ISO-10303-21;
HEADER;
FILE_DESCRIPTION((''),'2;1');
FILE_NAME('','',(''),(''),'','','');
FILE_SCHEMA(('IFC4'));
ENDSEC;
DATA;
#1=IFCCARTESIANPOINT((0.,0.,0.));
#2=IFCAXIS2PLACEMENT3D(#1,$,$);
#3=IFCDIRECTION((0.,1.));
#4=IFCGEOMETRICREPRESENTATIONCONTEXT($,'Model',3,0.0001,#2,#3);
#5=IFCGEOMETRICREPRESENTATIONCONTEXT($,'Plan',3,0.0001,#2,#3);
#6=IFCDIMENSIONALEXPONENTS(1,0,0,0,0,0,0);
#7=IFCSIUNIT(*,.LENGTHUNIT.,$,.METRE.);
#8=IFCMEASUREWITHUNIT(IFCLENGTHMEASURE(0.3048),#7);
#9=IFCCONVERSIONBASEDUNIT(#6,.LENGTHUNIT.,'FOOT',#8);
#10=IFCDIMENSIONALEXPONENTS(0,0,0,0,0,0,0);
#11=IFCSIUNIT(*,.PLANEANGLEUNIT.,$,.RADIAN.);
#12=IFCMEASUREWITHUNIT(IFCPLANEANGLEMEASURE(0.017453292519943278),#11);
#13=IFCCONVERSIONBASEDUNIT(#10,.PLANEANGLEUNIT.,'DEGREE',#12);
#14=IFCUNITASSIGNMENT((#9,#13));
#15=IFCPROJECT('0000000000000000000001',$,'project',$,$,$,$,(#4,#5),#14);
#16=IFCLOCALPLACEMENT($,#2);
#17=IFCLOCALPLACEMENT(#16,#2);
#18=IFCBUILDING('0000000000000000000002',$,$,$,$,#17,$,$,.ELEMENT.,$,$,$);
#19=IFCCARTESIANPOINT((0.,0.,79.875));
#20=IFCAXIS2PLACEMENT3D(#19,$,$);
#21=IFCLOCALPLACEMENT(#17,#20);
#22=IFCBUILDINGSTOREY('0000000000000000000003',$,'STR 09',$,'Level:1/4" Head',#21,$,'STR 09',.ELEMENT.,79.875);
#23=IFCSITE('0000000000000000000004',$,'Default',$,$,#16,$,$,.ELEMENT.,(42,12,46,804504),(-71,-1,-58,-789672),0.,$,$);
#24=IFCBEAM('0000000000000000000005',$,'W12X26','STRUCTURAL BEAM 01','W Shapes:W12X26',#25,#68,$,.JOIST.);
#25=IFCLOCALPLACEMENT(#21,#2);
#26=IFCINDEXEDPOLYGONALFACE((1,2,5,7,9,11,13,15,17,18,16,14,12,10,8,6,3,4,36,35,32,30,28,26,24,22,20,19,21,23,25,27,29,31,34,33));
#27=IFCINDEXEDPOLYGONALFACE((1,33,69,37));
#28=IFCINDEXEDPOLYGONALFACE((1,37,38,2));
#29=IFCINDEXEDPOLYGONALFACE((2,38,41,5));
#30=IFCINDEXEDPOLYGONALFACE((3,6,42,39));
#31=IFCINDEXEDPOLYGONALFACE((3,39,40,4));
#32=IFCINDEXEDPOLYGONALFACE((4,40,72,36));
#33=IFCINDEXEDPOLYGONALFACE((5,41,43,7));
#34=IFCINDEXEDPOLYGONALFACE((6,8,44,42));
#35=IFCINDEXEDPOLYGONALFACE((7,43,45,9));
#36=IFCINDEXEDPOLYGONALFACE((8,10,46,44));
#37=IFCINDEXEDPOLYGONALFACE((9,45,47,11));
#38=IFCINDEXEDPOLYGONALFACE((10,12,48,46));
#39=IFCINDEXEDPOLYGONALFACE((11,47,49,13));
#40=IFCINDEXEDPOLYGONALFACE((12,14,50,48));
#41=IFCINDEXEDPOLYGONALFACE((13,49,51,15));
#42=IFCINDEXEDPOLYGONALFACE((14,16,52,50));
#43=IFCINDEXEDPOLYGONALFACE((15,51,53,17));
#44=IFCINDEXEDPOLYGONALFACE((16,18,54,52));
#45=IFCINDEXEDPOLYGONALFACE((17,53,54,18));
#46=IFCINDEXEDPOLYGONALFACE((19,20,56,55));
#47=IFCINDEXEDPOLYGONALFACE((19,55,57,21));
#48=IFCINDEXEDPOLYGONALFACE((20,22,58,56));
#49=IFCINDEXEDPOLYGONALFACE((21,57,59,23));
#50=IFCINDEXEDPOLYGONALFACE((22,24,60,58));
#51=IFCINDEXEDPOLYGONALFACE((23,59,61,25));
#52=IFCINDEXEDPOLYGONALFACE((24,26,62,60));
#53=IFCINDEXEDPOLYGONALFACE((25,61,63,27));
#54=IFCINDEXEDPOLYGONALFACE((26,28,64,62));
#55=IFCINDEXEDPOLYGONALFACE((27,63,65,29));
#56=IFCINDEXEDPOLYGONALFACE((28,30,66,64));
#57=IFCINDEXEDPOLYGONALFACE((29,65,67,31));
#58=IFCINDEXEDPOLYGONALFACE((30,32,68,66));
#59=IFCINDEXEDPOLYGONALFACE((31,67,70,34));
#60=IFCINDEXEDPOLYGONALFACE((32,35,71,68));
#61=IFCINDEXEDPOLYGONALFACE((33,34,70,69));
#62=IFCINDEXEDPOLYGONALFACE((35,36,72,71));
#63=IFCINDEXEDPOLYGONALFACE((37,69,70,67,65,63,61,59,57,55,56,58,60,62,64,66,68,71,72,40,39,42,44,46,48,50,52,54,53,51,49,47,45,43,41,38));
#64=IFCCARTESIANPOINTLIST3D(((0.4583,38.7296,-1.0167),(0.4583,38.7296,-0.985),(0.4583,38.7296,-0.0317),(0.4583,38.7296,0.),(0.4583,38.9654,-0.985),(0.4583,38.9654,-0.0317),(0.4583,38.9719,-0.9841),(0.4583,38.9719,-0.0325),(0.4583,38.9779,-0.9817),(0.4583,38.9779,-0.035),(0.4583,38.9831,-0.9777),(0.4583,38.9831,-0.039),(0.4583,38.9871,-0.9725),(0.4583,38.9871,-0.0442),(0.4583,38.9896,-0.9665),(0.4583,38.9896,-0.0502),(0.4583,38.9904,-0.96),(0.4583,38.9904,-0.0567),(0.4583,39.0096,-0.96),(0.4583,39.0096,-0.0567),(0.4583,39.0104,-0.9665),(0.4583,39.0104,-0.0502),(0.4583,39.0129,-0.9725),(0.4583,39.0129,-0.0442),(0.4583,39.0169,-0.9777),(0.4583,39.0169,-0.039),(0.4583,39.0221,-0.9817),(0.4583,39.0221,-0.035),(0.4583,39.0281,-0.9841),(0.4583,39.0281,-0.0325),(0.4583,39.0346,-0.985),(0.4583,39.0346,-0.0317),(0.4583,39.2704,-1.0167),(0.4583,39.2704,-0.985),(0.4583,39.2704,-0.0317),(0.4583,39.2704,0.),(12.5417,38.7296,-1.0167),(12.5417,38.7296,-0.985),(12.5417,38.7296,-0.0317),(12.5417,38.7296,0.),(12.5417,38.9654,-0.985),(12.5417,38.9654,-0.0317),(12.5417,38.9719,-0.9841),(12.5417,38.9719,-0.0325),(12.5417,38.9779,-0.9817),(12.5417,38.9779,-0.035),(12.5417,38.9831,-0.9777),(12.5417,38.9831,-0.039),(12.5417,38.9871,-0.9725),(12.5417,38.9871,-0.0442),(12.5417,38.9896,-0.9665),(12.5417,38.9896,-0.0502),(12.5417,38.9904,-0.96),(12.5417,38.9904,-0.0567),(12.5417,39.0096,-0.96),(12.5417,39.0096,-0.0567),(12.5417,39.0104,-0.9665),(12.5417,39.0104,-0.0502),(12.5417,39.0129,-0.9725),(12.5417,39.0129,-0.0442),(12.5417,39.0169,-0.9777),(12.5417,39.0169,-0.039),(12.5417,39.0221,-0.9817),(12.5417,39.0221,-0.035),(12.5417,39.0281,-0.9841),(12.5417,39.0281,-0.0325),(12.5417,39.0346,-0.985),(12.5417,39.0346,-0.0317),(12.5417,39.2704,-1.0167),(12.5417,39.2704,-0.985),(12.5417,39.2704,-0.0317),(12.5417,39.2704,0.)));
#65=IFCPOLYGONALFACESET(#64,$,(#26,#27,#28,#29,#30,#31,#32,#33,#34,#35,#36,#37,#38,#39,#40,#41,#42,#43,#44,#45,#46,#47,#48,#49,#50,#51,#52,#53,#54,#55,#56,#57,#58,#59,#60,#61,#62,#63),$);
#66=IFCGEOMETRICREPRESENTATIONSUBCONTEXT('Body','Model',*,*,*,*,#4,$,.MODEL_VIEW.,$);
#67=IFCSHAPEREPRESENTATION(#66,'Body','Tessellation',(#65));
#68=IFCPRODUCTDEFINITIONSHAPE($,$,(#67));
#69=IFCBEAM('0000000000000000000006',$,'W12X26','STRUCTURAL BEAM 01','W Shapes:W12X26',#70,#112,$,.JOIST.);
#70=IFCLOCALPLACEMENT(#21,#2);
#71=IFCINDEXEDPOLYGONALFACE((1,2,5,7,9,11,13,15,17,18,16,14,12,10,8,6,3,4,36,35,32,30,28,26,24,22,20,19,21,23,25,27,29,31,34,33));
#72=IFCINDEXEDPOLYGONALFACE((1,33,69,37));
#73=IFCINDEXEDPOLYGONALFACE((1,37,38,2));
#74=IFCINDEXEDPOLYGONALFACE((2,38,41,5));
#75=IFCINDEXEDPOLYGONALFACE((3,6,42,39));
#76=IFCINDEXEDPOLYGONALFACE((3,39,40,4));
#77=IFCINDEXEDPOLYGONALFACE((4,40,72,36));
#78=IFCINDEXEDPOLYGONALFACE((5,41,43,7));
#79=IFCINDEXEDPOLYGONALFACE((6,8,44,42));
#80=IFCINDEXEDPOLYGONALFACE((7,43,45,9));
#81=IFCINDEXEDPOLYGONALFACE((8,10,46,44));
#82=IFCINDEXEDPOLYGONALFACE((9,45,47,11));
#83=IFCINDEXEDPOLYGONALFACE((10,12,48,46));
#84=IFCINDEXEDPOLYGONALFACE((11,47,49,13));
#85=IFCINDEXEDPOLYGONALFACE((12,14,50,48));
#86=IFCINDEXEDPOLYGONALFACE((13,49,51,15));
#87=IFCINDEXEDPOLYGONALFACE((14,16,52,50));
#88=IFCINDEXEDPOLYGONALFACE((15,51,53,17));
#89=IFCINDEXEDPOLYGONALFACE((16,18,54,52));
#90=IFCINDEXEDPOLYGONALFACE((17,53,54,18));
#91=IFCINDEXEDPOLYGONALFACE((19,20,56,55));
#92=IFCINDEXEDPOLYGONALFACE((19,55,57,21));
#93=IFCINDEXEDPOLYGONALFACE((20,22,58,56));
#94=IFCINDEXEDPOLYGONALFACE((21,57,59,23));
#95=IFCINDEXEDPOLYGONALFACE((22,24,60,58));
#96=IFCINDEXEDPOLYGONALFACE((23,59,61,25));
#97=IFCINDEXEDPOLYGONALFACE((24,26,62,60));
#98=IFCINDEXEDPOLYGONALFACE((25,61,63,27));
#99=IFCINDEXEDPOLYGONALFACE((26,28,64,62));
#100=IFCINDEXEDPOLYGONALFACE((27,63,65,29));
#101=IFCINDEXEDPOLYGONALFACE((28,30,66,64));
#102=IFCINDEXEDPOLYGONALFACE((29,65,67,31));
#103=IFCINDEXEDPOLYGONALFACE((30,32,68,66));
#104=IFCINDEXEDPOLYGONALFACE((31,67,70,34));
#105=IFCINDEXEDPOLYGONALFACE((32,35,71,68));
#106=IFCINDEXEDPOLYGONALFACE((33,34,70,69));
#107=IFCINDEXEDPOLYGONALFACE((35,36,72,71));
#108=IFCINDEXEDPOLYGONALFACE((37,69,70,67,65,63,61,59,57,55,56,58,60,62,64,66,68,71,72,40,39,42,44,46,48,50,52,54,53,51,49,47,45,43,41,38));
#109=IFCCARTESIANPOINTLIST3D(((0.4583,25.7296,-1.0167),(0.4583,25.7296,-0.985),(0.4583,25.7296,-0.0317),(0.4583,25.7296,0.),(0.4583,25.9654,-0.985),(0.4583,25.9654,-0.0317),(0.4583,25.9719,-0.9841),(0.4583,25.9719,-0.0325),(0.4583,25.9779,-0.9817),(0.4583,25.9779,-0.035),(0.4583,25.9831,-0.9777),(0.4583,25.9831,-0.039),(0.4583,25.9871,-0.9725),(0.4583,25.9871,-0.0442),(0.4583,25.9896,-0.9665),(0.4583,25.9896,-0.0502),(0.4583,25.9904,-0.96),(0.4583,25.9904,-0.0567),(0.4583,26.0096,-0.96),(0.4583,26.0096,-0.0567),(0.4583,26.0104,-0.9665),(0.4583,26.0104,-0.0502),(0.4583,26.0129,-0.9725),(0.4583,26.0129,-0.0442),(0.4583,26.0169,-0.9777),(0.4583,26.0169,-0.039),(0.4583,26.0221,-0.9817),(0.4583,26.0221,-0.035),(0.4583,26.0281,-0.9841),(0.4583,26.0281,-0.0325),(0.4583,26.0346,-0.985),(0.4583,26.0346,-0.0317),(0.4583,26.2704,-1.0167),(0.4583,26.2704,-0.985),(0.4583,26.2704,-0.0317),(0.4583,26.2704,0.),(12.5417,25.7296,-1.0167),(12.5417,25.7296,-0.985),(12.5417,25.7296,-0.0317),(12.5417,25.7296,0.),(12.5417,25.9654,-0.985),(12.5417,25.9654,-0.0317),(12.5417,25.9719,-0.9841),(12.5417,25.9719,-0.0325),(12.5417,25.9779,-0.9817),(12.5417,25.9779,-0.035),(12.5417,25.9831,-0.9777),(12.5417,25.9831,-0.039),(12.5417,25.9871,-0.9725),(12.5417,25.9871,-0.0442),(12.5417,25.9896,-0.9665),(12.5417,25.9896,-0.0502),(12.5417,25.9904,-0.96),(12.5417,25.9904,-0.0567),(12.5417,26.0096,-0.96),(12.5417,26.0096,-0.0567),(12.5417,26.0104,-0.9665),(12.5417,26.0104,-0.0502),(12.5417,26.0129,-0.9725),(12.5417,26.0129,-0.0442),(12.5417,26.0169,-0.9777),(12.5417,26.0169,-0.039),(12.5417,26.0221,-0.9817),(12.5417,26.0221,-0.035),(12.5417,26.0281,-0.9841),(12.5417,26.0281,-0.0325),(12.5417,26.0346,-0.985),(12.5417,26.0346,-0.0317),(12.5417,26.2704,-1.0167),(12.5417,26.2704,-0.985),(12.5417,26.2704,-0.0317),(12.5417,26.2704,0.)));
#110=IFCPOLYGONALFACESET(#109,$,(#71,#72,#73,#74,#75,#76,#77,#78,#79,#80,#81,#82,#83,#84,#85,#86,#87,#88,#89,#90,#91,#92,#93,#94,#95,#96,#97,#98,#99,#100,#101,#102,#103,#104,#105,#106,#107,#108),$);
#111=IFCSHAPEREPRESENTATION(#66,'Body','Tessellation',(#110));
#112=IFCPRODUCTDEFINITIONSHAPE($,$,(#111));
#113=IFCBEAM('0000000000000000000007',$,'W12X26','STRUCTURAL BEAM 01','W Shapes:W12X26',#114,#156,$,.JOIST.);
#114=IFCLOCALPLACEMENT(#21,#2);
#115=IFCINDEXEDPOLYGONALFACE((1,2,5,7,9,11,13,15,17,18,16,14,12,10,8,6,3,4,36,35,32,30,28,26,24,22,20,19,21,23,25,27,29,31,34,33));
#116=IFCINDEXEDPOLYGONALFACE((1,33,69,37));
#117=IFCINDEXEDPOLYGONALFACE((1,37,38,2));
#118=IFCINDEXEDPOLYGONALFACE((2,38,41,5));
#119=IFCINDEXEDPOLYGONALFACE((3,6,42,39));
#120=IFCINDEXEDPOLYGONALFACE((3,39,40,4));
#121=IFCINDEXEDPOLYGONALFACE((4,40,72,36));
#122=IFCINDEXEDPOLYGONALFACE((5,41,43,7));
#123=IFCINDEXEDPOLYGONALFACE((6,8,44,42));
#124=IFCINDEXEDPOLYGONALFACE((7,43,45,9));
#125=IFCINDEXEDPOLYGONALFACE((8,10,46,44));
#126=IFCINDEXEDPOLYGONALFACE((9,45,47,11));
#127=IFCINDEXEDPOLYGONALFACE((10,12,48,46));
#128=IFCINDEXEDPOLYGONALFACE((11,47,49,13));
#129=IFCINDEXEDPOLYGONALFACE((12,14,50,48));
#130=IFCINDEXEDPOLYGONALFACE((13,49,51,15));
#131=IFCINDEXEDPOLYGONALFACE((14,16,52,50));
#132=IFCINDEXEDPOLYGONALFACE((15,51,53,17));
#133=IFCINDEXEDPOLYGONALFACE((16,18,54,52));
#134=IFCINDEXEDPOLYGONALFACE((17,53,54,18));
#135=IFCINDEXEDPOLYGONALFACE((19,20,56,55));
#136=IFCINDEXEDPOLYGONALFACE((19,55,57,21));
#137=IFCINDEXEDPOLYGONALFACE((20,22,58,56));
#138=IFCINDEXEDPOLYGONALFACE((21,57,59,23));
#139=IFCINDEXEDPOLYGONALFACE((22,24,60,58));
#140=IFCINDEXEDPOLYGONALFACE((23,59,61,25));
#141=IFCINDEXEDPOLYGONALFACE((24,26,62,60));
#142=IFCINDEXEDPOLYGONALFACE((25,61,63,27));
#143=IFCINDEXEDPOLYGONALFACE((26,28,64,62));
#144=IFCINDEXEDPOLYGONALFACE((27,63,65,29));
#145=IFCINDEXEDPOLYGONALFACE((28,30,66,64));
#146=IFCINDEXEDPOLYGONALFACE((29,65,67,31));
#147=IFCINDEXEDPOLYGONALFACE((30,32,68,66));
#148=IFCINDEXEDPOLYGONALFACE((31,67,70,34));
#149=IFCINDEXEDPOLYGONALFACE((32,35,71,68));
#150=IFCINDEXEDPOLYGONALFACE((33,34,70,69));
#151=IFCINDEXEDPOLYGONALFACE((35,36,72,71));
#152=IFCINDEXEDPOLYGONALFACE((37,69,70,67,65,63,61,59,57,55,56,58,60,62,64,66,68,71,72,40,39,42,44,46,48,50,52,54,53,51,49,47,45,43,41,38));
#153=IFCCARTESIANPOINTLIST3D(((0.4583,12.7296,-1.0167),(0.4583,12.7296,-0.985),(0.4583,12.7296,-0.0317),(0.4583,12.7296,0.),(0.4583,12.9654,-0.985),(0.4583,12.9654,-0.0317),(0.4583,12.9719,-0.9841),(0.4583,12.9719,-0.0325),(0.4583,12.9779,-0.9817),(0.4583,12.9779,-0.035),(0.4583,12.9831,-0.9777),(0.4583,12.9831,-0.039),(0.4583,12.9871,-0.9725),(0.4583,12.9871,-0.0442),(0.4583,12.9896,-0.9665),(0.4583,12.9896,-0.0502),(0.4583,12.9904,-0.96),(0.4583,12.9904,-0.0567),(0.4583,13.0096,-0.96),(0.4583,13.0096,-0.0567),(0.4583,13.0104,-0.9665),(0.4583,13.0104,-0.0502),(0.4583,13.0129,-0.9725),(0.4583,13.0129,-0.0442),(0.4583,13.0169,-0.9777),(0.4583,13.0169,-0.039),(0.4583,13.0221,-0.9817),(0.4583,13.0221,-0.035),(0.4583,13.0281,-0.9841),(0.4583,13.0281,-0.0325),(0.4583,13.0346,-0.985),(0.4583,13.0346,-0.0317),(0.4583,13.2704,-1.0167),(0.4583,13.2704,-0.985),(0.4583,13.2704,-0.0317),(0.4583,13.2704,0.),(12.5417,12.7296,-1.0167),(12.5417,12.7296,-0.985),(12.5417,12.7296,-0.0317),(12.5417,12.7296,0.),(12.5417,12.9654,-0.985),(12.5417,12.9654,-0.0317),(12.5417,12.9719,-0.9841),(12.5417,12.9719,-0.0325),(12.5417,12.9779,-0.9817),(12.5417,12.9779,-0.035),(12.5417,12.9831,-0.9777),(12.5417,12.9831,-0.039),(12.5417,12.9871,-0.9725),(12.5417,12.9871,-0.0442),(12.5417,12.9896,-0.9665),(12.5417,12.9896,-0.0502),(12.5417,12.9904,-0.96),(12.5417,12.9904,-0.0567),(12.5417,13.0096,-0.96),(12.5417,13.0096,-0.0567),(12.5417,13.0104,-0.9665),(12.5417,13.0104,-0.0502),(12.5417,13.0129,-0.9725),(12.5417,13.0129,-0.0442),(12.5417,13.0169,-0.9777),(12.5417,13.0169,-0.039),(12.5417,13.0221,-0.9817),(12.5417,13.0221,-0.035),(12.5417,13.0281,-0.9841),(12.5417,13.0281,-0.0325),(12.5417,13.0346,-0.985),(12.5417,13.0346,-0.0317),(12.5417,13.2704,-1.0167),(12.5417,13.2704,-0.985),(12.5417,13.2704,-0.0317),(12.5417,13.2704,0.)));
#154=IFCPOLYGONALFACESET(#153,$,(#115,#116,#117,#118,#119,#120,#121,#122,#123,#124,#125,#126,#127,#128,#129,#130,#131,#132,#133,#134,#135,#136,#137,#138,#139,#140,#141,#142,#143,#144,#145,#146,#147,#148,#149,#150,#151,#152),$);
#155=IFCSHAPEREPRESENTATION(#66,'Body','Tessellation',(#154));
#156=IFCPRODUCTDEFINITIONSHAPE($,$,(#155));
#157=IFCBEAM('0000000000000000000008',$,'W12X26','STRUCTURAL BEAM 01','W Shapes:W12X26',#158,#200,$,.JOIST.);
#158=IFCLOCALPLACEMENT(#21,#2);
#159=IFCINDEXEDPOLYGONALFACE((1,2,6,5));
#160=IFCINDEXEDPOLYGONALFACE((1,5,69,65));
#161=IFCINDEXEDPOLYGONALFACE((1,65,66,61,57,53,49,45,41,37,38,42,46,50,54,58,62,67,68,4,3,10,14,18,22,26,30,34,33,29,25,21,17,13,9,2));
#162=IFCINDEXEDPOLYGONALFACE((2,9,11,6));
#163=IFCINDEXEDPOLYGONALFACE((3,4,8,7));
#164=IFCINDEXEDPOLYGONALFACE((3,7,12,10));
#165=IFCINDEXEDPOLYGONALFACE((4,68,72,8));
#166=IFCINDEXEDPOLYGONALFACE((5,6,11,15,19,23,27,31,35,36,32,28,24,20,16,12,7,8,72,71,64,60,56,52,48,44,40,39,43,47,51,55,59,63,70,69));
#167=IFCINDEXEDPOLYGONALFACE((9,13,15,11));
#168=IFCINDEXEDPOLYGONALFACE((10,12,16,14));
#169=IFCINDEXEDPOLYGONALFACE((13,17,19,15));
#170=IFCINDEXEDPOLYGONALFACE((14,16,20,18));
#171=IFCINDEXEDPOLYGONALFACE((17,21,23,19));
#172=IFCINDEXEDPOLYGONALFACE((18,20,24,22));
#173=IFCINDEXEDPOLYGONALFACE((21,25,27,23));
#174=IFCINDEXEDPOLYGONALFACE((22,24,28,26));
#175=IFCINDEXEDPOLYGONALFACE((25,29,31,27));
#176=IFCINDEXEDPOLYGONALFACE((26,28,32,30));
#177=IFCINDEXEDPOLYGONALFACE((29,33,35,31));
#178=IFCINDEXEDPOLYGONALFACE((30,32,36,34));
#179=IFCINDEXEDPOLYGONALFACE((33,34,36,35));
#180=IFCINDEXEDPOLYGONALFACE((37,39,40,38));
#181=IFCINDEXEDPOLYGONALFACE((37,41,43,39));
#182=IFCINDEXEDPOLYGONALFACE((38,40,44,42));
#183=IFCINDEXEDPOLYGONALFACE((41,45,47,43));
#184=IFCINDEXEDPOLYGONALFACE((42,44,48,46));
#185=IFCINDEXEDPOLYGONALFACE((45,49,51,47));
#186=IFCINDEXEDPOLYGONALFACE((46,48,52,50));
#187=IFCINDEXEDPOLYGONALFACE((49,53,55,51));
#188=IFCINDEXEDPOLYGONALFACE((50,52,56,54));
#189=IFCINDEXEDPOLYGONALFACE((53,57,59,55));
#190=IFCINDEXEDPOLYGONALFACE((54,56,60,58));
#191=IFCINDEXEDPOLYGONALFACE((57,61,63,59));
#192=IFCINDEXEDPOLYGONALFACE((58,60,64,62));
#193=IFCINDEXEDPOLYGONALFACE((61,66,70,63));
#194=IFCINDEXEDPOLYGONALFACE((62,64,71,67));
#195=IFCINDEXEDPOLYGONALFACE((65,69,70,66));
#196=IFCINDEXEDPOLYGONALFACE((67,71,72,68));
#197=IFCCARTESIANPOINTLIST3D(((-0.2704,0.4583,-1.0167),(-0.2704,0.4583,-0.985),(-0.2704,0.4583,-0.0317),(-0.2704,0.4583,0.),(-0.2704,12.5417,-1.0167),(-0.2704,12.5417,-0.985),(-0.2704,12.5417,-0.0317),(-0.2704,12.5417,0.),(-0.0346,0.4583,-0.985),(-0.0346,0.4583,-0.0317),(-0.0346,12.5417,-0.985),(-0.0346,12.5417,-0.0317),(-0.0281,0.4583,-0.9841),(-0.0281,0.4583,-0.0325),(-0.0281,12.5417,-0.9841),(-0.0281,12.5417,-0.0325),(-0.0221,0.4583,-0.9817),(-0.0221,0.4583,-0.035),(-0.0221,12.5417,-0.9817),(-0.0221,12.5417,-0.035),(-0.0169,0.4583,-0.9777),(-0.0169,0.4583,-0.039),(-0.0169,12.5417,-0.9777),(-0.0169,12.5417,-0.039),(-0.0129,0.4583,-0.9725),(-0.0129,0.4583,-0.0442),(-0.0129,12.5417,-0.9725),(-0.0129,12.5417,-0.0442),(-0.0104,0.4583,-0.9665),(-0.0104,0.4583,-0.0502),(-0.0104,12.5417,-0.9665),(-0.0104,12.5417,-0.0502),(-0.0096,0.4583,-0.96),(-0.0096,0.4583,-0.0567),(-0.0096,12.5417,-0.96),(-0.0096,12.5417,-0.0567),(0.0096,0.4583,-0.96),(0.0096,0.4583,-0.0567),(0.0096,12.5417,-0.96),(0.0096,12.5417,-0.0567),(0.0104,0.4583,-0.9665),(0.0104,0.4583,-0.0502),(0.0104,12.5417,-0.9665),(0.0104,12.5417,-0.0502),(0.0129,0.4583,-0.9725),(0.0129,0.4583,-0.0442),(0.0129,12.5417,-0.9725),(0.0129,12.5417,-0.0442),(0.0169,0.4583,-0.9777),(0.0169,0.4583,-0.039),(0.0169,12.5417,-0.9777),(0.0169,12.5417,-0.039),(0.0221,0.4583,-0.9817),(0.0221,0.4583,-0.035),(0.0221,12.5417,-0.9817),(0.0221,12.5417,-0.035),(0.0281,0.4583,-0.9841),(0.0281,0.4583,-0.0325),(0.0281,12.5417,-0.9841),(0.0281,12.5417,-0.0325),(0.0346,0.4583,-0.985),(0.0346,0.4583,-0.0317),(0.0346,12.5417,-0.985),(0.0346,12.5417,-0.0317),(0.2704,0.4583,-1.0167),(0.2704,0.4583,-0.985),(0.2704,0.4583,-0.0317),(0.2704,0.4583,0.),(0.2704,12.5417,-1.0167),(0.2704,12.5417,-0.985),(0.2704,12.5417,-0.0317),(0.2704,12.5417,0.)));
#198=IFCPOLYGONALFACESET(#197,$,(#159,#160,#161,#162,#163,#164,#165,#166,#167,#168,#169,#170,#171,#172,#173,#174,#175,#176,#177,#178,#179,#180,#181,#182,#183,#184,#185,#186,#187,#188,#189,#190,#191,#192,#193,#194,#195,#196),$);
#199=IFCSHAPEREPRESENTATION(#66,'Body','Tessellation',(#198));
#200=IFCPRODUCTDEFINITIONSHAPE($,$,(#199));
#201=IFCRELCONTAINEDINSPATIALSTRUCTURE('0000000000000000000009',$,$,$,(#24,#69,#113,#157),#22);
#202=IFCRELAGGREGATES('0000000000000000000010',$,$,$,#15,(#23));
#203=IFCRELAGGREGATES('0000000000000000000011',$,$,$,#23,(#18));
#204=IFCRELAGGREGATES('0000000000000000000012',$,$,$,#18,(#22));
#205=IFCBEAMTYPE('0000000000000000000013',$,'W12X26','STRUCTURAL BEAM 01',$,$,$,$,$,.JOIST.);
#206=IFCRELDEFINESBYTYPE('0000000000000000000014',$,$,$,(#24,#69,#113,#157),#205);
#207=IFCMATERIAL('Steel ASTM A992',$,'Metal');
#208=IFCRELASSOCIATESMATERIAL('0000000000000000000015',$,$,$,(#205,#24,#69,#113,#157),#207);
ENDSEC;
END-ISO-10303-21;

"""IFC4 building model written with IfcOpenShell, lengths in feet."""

from ifc_helpers import new_model, entity, si_unit, converted_unit, direction, frame, origin, place, context, subcontext, project, spatial, line, arc, indexed_curve, outline, extrude, source, transform, mapped, material, type_object, type_shapes, element, save


model = new_model("IFC4")

# Units and contexts
model_context = context("Model", 3, precision=0.0001, world=origin(), true_north=direction((0.0, 1.0)))
plan_context = context("Plan", 3, precision=0.0001, world=origin(), true_north=direction((0.0, 1.0)))
body_context = subcontext(model_context, "Body", "Model", "MODEL_VIEW")
ifc_project = project(units=[converted_unit("LENGTHUNIT", "FOOT", entity("IfcLengthMeasure", 0.3048), si_unit("LENGTHUNIT", "METRE"), dimensions=[1, 0, 0, 0, 0, 0, 0]), converted_unit("PLANEANGLEUNIT", "DEGREE", entity("IfcPlaneAngleMeasure", 0.017453292519943278), si_unit("PLANEANGLEUNIT", "RADIAN"), dimensions=[0, 0, 0, 0, 0, 0, 0])], contexts=[model_context, plan_context])

# Site, building, storey
site_placement = place(None, origin())
site = spatial("IfcSite", under=ifc_project, at=site_placement, Name="Default", CompositionType="ELEMENT", RefLatitude=(42, 12, 46, 804504), RefLongitude=(-71, -1, -58, -789672), RefElevation=0.0)
building_placement = place(site_placement, origin())
building = spatial("IfcBuilding", under=site, at=building_placement, CompositionType="ELEMENT")
storey_placement = place(building_placement, frame((0.0, 0.0, 79.875)))
storey = spatial("IfcBuildingStorey", under=building, at=storey_placement, Name="STR 09", ObjectType="Level:1/4\" Head", LongName="STR 09", CompositionType="ELEMENT", Elevation=79.875)

# Beams
ifc_material = material(Name="Steel ASTM A992", Category="Metal")
beam_type_1 = type_object("IfcBeamType", Name="W12X26", Description="STRUCTURAL BEAM 01", PredefinedType="JOIST", material=ifc_material)
shared_shape_1 = source(origin(), body_context, "Body", "SweptSolid", [
    extrude(outline(indexed_curve([(-0.2704, -0.4767), (-0.2704, -0.5083), (0.2704, -0.5083), (0.2704, -0.4767), (0.0346, -0.4767), (0.0169, -0.4693), (0.0096, -0.4517), (0.0096, 0.4517), (0.0169, 0.4693), (0.0346, 0.4767), (0.2704, 0.4767), (0.2704, 0.5083), (-0.2704, 0.5083), (-0.2704, 0.4767), (-0.0346, 0.4767), (-0.0169, 0.4693), (-0.0096, 0.4517), (-0.0096, -0.4517), (-0.0169, -0.4693), (-0.0346, -0.4767)], segments=[line(1, 2, 3, 4, 5), arc(5, 6, 7), line(7, 8), arc(8, 9, 10), line(10, 11, 12, 13, 14, 15), arc(15, 16, 17), line(17, 18), arc(18, 19, 20), line(20, 1)], self_intersect=False)), frame((-6.1033, 0.0, 0.0), z_axis=(-1.0, 0.0, 0.0), x_axis=(0.0, -1.0, 0.0)), (0.0, 0.0, -1.0), 12.0833),
])
type_shapes(beam_type_1, [shared_shape_1])
for number, where, name in (
    (1, (6.5617, 39.0, -0.5083), "W12X26"),
    (2, (6.5617, 26.0, -0.5083), "W12X26"),
    (3, (6.5617, 13.0, -0.5083), "W12X26"),
):
    element("IfcBeam", number, at=place(storey_placement, frame(where)), inside=storey, type_object=beam_type_1, material=ifc_material, Name=name, Description="STRUCTURAL BEAM 01", ObjectType="W Shapes:W12X26", PredefinedType="JOIST", context=body_context, shape_type="MappedRepresentation", body=[
        mapped(shared_shape_1, transform((0.0, 0.0, 0.0), scale=1.0)),
    ])
for number, where, z_axis, x_axis, name in (
    (4, (0.0, 6.5617, -0.5083), (0.0, 0.0, 1.0), (0.0, 1.0, 0.0), "W12X26"),
):
    element("IfcBeam", number, at=place(storey_placement, frame(where, z_axis=z_axis, x_axis=x_axis)), inside=storey, type_object=beam_type_1, material=ifc_material, Name=name, Description="STRUCTURAL BEAM 01", ObjectType="W Shapes:W12X26", PredefinedType="JOIST", context=body_context, shape_type="MappedRepresentation", body=[
        mapped(shared_shape_1, transform((0.0, 0.0, 0.0), scale=1.0)),
    ])

save(model, "model.ifc")
